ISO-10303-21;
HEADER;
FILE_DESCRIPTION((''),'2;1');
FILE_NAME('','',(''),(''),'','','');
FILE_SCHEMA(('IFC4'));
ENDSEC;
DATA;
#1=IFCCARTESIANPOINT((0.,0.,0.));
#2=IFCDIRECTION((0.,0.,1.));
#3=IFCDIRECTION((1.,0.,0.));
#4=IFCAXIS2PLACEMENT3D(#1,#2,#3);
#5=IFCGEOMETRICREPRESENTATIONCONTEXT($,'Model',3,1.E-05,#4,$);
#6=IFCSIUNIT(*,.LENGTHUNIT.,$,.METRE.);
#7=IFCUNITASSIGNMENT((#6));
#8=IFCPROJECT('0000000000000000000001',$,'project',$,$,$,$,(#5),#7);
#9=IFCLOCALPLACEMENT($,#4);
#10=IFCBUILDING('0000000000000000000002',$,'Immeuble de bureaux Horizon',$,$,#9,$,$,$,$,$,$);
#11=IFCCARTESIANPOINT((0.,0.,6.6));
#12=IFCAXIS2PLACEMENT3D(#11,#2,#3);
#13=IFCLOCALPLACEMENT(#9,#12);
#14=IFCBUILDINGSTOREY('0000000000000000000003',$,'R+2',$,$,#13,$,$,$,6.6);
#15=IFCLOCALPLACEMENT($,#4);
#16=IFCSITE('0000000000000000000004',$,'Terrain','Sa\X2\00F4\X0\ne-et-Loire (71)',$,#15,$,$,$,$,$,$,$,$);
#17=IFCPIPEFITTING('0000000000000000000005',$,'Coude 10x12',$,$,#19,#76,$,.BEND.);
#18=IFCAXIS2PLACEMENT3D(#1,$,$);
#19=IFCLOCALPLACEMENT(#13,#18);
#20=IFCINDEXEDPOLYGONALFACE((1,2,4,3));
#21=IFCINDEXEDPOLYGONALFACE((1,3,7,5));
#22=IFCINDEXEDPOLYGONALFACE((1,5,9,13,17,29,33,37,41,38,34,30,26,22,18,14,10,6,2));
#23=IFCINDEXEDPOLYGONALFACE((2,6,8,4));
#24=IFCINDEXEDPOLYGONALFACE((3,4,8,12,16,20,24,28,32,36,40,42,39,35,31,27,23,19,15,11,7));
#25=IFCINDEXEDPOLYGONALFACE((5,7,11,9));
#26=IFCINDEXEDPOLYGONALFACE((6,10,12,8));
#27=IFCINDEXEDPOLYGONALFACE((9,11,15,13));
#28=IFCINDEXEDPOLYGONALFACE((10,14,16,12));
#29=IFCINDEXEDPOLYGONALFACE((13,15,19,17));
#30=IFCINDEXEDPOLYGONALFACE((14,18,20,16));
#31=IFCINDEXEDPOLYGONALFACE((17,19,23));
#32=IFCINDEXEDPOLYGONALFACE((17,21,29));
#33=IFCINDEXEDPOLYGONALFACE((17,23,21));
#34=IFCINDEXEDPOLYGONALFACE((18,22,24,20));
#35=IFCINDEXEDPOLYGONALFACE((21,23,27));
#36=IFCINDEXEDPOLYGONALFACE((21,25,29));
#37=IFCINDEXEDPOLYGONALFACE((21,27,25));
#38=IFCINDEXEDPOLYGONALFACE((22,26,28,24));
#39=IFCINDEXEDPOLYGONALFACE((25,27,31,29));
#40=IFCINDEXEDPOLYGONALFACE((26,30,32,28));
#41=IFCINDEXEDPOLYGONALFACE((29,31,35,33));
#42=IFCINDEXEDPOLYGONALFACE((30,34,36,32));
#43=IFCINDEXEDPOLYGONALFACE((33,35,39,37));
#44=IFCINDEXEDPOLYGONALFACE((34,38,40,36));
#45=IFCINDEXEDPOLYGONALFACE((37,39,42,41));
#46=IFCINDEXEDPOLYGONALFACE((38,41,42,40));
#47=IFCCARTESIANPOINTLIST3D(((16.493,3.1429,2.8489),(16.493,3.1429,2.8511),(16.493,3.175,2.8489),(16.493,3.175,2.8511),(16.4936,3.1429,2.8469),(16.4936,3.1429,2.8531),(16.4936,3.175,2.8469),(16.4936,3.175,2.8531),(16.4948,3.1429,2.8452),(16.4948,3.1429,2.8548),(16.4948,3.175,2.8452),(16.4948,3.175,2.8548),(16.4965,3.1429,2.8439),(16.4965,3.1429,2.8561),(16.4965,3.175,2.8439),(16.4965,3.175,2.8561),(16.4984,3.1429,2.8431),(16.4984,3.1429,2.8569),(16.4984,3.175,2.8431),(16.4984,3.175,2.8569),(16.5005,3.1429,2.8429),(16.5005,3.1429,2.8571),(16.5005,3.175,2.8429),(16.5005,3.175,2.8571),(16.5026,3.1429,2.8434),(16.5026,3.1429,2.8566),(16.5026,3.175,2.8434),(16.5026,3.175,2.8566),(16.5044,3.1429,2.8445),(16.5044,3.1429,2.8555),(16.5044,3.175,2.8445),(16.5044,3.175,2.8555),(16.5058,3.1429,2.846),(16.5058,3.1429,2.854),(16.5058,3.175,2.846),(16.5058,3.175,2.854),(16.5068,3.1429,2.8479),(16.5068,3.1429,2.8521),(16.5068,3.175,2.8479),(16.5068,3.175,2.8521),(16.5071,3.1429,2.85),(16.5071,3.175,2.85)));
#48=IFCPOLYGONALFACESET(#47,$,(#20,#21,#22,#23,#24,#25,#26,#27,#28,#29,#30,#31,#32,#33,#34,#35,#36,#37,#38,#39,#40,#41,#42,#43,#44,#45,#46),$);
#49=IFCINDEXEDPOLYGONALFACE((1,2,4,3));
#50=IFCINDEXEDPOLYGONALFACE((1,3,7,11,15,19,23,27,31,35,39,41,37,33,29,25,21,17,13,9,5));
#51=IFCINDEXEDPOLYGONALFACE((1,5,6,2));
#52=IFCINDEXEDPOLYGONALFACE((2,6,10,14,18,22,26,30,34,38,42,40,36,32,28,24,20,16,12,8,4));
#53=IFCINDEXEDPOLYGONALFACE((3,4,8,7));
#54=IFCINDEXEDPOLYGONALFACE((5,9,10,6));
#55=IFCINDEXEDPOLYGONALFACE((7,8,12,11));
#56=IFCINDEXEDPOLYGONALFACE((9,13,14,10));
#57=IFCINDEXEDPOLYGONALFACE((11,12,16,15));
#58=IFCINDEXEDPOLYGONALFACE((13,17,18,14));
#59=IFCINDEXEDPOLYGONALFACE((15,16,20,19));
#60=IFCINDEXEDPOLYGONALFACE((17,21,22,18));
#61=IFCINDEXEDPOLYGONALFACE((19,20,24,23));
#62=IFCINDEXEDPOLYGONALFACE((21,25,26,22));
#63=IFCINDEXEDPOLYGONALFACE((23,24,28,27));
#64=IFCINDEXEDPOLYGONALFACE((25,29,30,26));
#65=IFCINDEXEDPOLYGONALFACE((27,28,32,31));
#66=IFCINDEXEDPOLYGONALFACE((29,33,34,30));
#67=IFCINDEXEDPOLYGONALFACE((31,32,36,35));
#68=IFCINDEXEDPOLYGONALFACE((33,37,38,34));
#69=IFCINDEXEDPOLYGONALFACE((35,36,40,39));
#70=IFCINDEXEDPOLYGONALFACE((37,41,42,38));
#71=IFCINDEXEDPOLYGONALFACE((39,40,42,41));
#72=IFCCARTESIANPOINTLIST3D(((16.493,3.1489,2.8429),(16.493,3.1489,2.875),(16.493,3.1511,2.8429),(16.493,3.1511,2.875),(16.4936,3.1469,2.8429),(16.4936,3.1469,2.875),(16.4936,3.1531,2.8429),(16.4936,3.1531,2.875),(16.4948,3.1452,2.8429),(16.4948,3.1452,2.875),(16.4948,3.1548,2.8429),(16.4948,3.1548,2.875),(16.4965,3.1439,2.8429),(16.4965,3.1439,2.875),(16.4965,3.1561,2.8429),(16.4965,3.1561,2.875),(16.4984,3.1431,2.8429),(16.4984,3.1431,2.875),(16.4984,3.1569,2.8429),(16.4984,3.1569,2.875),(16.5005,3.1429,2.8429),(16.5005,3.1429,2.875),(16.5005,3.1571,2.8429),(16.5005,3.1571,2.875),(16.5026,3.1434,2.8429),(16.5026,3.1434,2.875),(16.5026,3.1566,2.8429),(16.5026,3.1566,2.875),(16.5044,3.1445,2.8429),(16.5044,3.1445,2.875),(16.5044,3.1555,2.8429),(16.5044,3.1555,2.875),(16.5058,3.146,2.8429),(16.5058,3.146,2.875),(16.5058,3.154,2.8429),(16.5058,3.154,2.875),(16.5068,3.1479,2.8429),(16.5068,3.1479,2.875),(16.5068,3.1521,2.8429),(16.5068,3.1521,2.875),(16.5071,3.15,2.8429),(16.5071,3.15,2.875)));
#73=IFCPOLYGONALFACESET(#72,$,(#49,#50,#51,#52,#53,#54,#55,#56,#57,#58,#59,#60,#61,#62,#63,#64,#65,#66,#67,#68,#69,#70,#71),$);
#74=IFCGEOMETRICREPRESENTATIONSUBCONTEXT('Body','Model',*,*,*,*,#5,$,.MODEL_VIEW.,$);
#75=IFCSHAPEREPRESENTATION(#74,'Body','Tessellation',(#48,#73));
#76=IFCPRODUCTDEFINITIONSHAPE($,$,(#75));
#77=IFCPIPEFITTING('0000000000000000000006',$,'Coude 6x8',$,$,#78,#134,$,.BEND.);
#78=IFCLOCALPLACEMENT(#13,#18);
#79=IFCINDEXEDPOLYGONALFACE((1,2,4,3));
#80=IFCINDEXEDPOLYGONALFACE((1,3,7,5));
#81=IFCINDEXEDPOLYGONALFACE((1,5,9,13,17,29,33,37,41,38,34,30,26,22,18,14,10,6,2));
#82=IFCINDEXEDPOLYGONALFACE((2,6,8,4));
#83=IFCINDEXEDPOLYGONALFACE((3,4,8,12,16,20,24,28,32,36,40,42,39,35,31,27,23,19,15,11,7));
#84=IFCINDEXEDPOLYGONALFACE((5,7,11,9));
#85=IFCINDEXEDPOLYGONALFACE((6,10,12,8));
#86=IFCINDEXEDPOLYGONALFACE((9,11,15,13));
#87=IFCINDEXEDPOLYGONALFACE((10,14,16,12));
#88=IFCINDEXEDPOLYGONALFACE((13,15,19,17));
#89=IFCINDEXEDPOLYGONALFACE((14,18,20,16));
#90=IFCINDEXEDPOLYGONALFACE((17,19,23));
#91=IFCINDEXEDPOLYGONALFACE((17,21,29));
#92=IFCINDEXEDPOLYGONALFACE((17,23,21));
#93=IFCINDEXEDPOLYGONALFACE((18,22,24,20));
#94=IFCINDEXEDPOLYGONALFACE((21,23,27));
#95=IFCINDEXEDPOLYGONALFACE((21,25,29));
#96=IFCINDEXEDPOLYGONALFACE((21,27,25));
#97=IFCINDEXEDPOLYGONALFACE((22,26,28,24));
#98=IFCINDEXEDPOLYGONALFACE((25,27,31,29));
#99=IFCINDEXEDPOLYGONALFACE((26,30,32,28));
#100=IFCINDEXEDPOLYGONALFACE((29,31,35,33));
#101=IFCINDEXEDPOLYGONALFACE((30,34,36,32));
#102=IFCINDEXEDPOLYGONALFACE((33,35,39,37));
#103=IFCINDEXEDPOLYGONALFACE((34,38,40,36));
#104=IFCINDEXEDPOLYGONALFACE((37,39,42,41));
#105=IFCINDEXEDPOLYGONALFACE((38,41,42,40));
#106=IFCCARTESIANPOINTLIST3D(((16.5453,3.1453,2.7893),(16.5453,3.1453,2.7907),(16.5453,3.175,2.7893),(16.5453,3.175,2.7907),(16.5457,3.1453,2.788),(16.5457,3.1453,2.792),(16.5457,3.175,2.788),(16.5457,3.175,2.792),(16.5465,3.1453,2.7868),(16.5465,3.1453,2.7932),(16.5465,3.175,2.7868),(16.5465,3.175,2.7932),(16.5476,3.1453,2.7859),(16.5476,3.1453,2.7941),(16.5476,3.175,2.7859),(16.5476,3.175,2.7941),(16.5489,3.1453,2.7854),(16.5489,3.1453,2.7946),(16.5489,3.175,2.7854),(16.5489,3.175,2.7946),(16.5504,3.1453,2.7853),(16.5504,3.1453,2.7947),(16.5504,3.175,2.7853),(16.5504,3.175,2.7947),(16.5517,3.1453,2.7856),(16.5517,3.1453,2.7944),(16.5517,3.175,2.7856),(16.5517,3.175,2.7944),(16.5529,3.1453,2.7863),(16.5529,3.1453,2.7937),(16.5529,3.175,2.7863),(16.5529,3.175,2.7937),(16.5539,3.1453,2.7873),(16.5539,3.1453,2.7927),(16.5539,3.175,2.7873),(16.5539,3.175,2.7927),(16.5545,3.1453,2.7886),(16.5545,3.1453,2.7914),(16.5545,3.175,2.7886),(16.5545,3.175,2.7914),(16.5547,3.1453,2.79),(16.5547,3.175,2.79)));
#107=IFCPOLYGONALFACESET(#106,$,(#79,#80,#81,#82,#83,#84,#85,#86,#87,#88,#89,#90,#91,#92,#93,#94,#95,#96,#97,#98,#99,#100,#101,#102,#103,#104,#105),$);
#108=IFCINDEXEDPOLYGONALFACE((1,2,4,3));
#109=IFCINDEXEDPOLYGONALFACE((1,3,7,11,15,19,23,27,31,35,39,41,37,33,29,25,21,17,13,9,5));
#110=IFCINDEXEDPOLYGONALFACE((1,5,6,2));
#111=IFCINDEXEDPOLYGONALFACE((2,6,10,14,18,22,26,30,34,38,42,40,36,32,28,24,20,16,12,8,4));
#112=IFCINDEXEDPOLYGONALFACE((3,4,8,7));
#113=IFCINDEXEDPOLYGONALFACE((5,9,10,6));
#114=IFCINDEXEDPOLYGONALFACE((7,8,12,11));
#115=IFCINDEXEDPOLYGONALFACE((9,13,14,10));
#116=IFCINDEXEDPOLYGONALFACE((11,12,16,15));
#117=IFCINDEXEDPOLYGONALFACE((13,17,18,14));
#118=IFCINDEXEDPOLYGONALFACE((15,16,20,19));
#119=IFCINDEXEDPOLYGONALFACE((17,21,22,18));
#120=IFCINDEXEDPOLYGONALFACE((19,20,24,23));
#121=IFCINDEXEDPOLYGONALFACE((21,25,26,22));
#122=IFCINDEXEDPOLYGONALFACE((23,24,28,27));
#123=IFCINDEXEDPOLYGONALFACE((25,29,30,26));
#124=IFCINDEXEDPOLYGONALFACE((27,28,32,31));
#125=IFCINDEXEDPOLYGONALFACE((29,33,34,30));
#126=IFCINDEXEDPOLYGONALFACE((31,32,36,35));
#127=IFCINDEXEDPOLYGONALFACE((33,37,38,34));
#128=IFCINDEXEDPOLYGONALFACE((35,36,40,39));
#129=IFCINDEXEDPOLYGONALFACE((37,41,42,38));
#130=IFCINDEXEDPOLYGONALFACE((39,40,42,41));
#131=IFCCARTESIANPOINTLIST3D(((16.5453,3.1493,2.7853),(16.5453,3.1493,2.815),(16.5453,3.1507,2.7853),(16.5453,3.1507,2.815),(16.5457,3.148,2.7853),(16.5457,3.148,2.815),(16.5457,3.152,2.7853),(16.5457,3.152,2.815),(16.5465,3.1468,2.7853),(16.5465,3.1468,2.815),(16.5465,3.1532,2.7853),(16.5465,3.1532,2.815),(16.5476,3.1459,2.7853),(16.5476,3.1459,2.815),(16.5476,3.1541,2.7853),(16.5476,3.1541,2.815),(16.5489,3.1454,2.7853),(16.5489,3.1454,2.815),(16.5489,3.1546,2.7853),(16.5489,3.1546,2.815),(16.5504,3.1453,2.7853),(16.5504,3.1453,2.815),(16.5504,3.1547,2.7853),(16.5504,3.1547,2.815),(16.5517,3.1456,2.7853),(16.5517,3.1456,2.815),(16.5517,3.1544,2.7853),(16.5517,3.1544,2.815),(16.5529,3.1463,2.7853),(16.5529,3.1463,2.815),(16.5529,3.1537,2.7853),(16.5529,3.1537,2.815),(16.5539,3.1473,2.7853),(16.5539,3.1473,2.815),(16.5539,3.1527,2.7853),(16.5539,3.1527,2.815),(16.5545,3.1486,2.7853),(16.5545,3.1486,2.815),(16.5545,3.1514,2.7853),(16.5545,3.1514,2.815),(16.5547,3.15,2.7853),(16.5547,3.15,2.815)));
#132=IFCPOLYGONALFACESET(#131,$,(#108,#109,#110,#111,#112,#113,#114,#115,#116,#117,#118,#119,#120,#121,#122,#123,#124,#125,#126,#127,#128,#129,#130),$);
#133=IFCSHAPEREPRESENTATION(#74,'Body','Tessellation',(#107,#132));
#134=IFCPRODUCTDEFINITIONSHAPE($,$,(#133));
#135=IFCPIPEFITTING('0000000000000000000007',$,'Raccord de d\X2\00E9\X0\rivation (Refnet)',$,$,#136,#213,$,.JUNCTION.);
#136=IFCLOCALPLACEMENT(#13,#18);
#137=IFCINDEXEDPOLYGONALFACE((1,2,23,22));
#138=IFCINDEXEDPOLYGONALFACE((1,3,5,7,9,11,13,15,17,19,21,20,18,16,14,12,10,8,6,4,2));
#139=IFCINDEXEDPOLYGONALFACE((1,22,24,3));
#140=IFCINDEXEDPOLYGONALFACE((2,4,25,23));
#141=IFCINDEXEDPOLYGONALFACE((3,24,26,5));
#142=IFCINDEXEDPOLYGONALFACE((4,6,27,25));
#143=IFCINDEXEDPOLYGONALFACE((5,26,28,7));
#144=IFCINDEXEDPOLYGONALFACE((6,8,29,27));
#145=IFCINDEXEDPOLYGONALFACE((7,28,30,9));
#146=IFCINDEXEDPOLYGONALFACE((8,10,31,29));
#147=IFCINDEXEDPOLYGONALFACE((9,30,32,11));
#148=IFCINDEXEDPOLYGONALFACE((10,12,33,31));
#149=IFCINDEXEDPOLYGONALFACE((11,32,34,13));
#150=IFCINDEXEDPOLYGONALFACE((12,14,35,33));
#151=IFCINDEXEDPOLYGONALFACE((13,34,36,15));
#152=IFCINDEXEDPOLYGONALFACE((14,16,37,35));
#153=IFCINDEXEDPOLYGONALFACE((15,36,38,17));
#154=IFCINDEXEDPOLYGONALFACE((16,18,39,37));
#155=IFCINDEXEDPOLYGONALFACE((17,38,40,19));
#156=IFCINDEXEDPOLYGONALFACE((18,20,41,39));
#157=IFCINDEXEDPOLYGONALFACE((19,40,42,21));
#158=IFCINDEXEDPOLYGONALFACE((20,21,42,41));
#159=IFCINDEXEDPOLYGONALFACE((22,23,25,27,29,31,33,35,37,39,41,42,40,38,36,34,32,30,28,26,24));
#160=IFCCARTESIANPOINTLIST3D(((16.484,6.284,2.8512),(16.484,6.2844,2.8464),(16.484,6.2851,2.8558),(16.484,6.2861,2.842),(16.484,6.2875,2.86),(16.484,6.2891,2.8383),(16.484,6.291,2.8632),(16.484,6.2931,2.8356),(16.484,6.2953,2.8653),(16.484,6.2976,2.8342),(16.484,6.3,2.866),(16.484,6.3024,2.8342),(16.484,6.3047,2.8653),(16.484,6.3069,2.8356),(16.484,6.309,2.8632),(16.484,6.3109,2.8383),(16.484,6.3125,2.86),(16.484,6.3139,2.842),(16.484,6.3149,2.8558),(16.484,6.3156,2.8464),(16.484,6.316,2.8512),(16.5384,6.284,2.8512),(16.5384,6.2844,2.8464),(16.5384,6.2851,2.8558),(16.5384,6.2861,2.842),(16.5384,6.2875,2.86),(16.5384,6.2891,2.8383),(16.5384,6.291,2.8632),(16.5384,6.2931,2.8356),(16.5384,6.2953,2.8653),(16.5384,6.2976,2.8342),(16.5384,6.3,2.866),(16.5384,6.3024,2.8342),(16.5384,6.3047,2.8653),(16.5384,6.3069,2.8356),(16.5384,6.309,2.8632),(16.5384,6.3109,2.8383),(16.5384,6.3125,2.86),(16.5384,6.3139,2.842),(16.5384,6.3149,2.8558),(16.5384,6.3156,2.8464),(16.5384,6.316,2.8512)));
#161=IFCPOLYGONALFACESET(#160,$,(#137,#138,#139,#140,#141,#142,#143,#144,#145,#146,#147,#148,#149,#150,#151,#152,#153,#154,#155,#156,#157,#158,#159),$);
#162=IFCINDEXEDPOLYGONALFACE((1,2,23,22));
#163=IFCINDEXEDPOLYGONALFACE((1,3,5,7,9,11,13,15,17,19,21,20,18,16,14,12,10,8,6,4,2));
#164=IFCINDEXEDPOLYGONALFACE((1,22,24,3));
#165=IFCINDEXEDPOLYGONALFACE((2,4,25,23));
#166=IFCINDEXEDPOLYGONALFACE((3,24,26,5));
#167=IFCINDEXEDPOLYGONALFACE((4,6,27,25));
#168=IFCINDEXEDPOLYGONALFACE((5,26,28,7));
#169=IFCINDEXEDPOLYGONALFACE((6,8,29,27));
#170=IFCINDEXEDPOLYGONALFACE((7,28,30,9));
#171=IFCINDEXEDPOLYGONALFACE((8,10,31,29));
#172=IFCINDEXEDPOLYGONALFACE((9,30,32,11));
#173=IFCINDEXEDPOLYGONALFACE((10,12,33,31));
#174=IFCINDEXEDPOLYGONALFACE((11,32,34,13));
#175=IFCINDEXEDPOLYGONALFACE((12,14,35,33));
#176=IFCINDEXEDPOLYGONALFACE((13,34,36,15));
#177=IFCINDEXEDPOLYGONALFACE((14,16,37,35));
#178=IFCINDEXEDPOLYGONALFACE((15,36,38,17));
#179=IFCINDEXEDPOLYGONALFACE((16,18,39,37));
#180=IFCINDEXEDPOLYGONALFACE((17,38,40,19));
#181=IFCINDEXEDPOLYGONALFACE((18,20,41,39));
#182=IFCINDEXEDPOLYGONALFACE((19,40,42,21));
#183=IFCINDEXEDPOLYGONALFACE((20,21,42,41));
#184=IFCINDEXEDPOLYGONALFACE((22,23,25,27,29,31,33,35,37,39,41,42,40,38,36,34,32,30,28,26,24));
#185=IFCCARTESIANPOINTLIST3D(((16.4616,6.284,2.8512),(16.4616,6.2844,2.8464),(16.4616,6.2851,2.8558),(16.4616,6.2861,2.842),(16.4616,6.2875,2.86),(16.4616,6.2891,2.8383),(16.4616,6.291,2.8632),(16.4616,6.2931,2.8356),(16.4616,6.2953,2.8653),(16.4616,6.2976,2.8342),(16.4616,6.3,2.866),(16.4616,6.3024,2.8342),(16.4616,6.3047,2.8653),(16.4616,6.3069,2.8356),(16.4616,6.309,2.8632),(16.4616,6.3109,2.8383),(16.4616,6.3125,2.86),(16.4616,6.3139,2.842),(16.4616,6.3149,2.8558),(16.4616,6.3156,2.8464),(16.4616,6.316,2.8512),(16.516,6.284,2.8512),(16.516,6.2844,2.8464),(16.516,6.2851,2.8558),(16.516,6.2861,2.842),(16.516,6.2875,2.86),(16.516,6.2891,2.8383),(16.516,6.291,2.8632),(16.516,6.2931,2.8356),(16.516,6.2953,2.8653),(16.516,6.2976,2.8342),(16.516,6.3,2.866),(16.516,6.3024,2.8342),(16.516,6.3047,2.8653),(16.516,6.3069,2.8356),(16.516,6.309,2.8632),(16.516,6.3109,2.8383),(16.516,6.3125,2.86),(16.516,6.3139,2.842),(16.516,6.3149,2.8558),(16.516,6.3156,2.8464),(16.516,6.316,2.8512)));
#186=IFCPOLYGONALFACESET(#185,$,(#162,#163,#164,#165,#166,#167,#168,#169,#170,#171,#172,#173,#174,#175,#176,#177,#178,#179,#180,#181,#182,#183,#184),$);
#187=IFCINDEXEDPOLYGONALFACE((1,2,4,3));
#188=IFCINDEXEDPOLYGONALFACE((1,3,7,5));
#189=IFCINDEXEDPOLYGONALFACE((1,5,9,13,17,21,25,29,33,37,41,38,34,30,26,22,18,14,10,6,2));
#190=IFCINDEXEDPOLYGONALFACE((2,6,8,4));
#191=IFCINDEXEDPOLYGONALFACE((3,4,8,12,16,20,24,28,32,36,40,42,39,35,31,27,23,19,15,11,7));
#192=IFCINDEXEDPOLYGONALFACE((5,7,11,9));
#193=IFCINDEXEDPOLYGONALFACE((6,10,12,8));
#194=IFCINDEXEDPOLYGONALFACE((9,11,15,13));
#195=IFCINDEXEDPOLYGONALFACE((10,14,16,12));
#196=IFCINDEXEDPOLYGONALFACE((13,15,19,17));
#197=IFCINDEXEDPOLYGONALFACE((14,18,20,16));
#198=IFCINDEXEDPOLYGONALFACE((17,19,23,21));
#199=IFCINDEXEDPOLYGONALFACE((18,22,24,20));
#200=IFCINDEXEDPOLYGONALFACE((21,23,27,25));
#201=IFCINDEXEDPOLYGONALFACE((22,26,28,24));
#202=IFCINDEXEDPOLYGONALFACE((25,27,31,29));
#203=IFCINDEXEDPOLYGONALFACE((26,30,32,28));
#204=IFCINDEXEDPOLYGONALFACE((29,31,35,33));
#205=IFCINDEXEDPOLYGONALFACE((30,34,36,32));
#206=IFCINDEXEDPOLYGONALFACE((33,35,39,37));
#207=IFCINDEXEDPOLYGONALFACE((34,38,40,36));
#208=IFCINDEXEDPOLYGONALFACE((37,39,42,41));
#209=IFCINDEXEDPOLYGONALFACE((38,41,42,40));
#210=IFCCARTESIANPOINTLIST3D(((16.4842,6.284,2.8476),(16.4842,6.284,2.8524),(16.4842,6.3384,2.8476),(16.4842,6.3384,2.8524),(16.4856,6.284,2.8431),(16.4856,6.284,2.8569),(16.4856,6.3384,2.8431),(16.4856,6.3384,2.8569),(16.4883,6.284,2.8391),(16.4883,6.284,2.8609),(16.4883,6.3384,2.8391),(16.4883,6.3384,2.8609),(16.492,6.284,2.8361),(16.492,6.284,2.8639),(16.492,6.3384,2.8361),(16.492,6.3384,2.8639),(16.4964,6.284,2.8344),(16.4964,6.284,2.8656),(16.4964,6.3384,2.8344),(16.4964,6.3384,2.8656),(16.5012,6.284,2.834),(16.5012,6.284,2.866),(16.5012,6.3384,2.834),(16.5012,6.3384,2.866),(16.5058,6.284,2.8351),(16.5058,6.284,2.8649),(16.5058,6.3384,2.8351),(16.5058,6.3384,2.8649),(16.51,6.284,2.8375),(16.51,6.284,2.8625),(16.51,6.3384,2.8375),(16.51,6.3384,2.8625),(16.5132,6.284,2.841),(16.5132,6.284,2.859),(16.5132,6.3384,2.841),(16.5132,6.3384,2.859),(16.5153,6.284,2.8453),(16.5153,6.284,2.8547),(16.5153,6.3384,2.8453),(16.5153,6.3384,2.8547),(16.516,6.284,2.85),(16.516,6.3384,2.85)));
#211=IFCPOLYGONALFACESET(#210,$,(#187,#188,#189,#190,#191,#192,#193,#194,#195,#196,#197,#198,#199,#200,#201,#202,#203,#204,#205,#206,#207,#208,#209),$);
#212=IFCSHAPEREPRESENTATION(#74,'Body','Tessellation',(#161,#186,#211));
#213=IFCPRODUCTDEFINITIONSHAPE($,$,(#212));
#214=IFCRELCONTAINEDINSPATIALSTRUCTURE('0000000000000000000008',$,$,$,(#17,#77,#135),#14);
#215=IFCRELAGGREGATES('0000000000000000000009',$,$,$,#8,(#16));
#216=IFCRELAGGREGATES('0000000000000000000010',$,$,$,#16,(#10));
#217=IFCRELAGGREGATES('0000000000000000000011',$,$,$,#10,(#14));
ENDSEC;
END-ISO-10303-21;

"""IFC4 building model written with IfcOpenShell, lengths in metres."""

from ifc_helpers import new_model, si_unit, frame, origin_with_axes, place, context, subcontext, project, spatial, circle, extrude, element, save


model = new_model("IFC4")

# Units and contexts
model_context = context("Model", 3, precision=1e-05, world=origin_with_axes())
body_context = subcontext(model_context, "Body", "Model", "MODEL_VIEW")
ifc_project = project(units=[si_unit("LENGTHUNIT", "METRE")], contexts=[model_context])

# Site, building, storey
site_placement = place(None, origin_with_axes())
site = spatial("IfcSite", under=ifc_project, at=site_placement, Name="Terrain", Description="Saône-et-Loire (71)")
building_placement = place(None, origin_with_axes())
building = spatial("IfcBuilding", under=site, at=building_placement, Name="Immeuble de bureaux Horizon")
storey_placement = place(building_placement, frame((0.0, 0.0, 6.6), z_axis=(0.0, 0.0, 1.0), x_axis=(1.0, 0.0, 0.0)))
storey = spatial("IfcBuildingStorey", under=building, at=storey_placement, Name="R+2", Elevation=6.6)

# Pipe fittings
pipe_fitting_1_placement = place(storey_placement, frame((16.5, 3.15, 2.85), z_axis=(0.0, 0.0, 1.0), x_axis=(1.0, 0.0, 0.0)))
element("IfcPipeFitting", 1, at=pipe_fitting_1_placement, inside=storey, Name="Coude 10x12", PredefinedType="BEND", context=body_context, shape_type="SweptSolid", body=[
    extrude(circle(Radius=0.0071), frame((0.0, -0.0071, 0.0), z_axis=(0.0, 1.0, 0.0), x_axis=(1.0, 0.0, 0.0)), (0.0, 0.0, 1.0), 0.0321),
    extrude(circle(Radius=0.0071), frame((0.0, 0.0, -0.0071), z_axis=(0.0, 0.0, 1.0), x_axis=(1.0, 0.0, 0.0)), (0.0, 0.0, 1.0), 0.0321),
])
pipe_fitting_2_placement = place(storey_placement, frame((16.55, 3.15, 2.79), z_axis=(0.0, 0.0, 1.0), x_axis=(1.0, 0.0, 0.0)))
element("IfcPipeFitting", 2, at=pipe_fitting_2_placement, inside=storey, Name="Coude 6x8", PredefinedType="BEND", context=body_context, shape_type="SweptSolid", body=[
    extrude(circle(Radius=0.0047), frame((0.0, -0.0047, 0.0), z_axis=(0.0, 1.0, 0.0), x_axis=(1.0, 0.0, 0.0)), (0.0, 0.0, 1.0), 0.0297),
    extrude(circle(Radius=0.0047), frame((0.0, 0.0, -0.0047), z_axis=(0.0, 0.0, 1.0), x_axis=(1.0, 0.0, 0.0)), (0.0, 0.0, 1.0), 0.0297),
])
pipe_fitting_3_placement = place(storey_placement, frame((16.5, 6.3, 2.85), z_axis=(0.0, 0.0, 1.0), x_axis=(1.0, 0.0, 0.0)))
element("IfcPipeFitting", 3, at=pipe_fitting_3_placement, inside=storey, Name="Raccord de dérivation (Refnet)", PredefinedType="JUNCTION", context=body_context, shape_type="SweptSolid", body=[
    extrude(circle(Radius=0.016), frame((-0.016, 0.0, 0.0), z_axis=(1.0, 0.0, 0.0), x_axis=(0.0, 0.0, 1.0)), (0.0, 0.0, 1.0), 0.0544),
    extrude(circle(Radius=0.016), frame((0.016, 0.0, 0.0), z_axis=(-1.0, 0.0, 0.0), x_axis=(0.0, 0.0, 1.0)), (0.0, 0.0, 1.0), 0.0544),
    extrude(circle(Radius=0.016), frame((0.0, -0.016, 0.0), z_axis=(0.0, 1.0, 0.0), x_axis=(1.0, 0.0, 0.0)), (0.0, 0.0, 1.0), 0.0544),
])

save(model, "model.ifc")
